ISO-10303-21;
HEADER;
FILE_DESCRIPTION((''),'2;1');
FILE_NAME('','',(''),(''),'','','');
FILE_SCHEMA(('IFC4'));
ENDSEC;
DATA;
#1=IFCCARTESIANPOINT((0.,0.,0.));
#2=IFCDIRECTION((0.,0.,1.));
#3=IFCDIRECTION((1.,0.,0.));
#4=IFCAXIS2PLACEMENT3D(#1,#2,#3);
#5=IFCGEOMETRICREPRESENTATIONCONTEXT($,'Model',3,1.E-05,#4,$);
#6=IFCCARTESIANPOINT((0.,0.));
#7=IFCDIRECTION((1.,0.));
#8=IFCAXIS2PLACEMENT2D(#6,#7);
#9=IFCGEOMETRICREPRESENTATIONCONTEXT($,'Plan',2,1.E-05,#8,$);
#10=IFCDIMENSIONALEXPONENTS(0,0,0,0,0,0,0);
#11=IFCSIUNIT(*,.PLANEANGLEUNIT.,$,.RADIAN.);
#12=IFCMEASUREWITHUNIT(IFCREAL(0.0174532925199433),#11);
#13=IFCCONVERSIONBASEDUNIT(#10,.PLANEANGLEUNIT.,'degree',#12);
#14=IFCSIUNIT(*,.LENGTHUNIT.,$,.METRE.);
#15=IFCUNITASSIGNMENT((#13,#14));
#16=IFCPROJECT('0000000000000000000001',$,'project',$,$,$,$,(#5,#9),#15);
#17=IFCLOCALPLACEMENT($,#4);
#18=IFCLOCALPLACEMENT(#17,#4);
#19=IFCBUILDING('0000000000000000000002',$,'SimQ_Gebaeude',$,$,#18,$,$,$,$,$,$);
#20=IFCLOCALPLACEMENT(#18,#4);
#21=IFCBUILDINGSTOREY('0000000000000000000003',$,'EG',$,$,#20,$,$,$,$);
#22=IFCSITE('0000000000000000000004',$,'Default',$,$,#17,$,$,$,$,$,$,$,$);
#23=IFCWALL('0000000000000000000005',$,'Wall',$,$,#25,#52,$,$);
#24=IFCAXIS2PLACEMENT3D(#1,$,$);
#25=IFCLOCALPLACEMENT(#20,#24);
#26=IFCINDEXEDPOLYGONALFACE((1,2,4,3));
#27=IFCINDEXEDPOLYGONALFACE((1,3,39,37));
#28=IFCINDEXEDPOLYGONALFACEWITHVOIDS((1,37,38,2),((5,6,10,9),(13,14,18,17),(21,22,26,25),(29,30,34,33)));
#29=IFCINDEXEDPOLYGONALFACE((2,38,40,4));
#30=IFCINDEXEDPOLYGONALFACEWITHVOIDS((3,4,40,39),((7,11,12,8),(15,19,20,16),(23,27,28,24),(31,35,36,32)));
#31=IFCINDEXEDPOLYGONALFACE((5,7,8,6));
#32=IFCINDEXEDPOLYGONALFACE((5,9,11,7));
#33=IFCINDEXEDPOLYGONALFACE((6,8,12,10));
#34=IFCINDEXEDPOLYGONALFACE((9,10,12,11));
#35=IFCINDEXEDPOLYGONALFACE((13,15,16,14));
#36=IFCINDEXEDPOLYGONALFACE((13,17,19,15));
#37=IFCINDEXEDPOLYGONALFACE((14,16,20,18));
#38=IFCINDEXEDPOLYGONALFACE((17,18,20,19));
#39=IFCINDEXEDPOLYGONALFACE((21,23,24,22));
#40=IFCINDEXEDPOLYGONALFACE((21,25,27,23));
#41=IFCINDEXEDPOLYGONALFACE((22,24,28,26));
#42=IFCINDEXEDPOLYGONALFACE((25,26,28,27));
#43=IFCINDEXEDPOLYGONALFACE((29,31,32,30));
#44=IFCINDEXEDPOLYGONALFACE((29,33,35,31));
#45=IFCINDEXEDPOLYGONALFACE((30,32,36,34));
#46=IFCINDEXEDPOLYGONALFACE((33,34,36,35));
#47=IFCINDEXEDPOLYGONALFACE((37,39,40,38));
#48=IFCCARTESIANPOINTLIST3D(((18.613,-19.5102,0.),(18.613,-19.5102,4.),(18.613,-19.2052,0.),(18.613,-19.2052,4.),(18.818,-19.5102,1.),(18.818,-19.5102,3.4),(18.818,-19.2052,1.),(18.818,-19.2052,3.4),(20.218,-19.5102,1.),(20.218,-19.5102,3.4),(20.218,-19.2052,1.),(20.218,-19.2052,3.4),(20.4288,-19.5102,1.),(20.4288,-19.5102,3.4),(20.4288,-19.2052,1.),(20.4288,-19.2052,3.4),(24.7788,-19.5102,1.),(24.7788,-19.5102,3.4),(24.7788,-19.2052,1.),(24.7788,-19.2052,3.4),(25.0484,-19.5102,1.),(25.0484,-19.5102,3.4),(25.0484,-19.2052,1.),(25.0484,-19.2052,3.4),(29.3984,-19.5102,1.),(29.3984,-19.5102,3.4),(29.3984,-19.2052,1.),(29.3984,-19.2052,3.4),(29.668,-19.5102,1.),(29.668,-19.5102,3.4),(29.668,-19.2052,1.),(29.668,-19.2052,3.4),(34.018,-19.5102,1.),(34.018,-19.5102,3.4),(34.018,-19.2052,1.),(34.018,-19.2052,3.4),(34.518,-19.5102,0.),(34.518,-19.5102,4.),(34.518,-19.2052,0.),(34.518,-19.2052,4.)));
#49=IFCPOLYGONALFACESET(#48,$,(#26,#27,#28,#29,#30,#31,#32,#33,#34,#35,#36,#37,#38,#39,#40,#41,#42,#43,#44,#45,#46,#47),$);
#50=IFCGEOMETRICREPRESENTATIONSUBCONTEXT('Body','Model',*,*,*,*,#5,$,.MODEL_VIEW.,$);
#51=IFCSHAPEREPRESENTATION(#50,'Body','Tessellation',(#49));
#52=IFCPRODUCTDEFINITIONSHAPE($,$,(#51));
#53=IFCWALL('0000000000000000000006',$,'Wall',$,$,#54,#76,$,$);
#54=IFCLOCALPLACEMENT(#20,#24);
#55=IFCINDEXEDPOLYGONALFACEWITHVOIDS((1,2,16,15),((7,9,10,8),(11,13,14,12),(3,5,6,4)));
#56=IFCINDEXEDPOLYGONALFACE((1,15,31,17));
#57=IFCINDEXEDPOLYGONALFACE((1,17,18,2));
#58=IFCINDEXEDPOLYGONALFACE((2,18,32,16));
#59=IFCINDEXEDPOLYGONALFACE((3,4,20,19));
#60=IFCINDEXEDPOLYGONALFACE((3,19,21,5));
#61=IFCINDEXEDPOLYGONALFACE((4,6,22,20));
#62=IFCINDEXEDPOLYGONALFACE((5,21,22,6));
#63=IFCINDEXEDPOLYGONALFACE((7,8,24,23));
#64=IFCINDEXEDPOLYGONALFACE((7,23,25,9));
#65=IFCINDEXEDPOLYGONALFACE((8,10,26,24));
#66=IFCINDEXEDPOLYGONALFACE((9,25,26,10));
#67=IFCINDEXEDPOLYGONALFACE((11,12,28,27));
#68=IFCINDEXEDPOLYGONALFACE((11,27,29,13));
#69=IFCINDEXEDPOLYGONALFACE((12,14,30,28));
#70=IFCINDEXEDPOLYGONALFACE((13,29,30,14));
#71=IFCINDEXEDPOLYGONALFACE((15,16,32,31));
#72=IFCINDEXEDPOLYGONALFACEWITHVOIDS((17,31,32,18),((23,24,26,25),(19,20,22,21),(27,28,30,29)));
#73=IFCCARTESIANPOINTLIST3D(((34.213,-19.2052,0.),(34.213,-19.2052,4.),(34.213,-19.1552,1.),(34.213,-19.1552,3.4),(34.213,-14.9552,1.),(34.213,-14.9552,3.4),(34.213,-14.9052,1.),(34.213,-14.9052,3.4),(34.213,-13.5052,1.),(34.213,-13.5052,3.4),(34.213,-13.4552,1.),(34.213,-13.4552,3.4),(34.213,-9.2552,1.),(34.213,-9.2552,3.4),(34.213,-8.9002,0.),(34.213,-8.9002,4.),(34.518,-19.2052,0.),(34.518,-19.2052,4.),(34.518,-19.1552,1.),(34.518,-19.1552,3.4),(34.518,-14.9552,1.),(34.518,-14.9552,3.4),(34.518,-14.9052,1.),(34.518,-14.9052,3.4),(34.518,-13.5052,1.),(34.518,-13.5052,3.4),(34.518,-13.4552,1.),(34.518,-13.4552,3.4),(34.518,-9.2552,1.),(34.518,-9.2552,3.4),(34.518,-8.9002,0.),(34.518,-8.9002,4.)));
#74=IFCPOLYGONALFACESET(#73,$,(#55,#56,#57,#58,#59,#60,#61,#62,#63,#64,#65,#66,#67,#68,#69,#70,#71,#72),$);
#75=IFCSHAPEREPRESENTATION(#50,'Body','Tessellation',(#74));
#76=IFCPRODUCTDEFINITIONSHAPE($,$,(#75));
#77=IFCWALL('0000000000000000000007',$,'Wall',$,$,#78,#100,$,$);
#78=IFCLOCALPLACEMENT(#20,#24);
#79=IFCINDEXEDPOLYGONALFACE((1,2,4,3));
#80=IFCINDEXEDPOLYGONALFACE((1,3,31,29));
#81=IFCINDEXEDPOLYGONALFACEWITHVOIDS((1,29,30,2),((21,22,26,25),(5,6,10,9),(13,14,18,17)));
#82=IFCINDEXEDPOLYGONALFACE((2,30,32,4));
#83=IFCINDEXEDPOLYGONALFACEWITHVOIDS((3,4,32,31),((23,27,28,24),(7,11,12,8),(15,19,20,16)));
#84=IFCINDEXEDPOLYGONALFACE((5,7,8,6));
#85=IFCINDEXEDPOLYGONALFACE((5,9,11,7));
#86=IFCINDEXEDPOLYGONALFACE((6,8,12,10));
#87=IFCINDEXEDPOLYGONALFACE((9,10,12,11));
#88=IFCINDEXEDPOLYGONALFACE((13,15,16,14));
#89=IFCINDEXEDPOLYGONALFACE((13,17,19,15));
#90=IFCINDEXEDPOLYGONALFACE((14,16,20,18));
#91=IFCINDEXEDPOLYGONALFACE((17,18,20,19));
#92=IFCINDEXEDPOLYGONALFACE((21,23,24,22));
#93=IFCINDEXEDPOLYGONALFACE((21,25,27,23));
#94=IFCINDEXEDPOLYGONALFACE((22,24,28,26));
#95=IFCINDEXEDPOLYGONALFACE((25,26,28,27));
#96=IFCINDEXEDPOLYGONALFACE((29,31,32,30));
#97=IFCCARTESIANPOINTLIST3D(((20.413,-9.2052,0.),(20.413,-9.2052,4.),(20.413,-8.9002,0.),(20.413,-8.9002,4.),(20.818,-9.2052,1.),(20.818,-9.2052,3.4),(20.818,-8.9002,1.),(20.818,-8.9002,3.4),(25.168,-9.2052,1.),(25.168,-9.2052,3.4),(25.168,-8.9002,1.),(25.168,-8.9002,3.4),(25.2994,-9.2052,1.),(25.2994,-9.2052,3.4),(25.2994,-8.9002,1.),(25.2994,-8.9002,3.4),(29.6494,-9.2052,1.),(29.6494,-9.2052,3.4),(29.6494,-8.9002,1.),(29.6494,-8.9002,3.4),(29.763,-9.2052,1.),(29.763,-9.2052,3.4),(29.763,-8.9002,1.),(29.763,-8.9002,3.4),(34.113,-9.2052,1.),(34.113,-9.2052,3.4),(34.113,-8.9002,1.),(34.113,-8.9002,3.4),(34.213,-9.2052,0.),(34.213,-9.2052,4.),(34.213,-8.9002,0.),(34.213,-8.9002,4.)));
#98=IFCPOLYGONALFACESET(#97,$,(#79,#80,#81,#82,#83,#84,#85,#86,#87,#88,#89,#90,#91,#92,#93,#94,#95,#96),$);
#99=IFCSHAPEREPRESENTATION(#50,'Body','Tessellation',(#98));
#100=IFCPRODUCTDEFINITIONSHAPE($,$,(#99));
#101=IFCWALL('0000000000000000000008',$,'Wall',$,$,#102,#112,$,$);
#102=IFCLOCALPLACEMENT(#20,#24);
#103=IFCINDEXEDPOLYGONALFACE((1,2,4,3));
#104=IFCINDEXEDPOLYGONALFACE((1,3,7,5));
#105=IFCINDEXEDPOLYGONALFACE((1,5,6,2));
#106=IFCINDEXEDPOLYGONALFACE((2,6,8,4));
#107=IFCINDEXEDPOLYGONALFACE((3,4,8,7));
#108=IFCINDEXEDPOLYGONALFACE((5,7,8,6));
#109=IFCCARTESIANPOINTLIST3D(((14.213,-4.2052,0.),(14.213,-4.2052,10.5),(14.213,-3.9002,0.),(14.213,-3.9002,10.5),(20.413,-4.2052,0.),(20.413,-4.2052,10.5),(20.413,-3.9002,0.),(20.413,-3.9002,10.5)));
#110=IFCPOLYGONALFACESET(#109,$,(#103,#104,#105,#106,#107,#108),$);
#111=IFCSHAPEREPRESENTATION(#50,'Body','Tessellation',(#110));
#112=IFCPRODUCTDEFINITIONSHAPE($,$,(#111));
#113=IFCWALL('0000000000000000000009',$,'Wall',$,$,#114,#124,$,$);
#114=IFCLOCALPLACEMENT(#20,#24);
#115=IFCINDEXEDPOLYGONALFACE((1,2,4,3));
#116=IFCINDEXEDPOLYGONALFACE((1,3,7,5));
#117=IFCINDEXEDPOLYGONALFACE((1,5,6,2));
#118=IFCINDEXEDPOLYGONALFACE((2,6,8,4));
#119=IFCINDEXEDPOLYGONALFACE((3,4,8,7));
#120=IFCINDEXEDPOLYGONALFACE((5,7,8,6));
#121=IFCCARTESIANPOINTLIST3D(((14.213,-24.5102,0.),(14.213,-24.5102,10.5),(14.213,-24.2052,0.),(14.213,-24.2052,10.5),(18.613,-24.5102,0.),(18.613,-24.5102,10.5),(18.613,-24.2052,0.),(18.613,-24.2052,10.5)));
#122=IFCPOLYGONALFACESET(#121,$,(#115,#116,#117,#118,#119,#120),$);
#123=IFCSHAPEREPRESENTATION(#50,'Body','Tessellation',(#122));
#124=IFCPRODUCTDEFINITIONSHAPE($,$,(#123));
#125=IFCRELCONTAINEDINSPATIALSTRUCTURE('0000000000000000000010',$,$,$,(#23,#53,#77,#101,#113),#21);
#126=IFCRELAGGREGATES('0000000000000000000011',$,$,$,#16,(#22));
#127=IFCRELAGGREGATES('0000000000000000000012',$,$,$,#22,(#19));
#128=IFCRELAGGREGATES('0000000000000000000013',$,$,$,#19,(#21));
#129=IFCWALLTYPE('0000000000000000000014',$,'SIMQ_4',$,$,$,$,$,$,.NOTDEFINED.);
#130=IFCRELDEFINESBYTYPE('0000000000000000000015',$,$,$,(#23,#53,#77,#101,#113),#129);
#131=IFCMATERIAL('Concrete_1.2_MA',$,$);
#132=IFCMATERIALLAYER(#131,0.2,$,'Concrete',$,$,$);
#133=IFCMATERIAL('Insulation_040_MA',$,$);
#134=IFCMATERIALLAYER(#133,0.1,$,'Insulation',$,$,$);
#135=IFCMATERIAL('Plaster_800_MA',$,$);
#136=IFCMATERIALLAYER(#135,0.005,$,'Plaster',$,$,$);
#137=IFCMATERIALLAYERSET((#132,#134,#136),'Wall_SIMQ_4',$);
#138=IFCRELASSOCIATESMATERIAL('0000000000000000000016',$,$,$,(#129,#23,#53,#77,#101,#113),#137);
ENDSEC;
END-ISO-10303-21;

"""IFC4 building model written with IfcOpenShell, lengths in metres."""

from ifc_helpers import new_model, entity, si_unit, converted_unit, frame, origin_with_axes, origin_2d_with_axis, place, context, subcontext, project, spatial, line, indexed_curve, outline, extrude, source, transform, mapped, material, layer, layer_set, layer_usage, type_object, element, save


model = new_model("IFC4")

# Units and contexts
model_context = context("Model", 3, precision=1e-05, world=origin_with_axes())
plan_context = context("Plan", 2, precision=1e-05, world=origin_2d_with_axis())
body_context_1 = subcontext(model_context, "Body", "Model", "MODEL_VIEW")
ifc_project = project(units=[converted_unit("PLANEANGLEUNIT", "degree", entity("IfcReal", 0.0174532925199433), si_unit("PLANEANGLEUNIT", "RADIAN"), dimensions=[0, 0, 0, 0, 0, 0, 0]), si_unit("LENGTHUNIT", "METRE")], contexts=[model_context, plan_context])

# Site, building, storey
site_placement = place(None, origin_with_axes())
site = spatial("IfcSite", under=ifc_project, at=site_placement, Name="Default")
building_placement = place(site_placement, origin_with_axes())
building = spatial("IfcBuilding", under=site, at=building_placement, Name="SimQ_Gebaeude")
storey_placement = place(building_placement, origin_with_axes())
storey = spatial("IfcBuildingStorey", under=building, at=storey_placement, Name="EG")

# Shared definitions
ifc_material_1 = material(Name="Insulation_040_MA")
ifc_material_2 = material(Name="Concrete_1.2_MA")

# Shared definitions
ifc_layer_1 = layer(ifc_material_2, 0.2, Name="Concrete")
ifc_layer_2 = layer(ifc_material_1, 0.1, Name="Insulation")
ifc_material_3 = material(Name="Plaster_800_MA")
ifc_layer_3 = layer(ifc_material_3, 0.005, Name="Plaster")
ifc_layer_set_1 = layer_set([ifc_layer_1, ifc_layer_2, ifc_layer_3], Name="Wall_SIMQ_4")
wall_type_1 = type_object("IfcWallType", Name="SIMQ_4", PredefinedType="NOTDEFINED", material=ifc_layer_set_1)
shared_shape_1 = source(origin_with_axes(), body_context_1, "Body", "SweptSolid", [
    extrude(outline(indexed_curve([(0.0, 0.0), (4.35, 0.0), (4.35, 2.4), (0.0, 2.4)], segments=[line(1, 2, 3, 4, 1)])), frame((0.0, -0.6, 0.0), z_axis=(0.0, -1.0, 0.0), x_axis=(1.0, 0.0, 0.0)), (0.0, 0.0, -1.0), 1.2),
])

# Walls, openings
ifc_layer_usage_1 = layer_usage(ifc_layer_set_1, "AXIS2", "POSITIVE", 0.0)
wall_1_placement = place(storey_placement, frame((18.613, -19.5102, 0.0), z_axis=(0.0, 0.0, 1.0), x_axis=(1.0, 0.0, 0.0)))
wall_1 = element("IfcWall", 1, at=wall_1_placement, inside=storey, type_object=wall_type_1, material=ifc_layer_usage_1, Name="Wall", context=body_context_1, shape_type="SweptSolid", body=[
    extrude(outline(indexed_curve([(0.0, 0.0), (0.0, 0.305), (15.905, 0.305), (15.905, 0.0), (0.0, 0.0)], self_intersect=False)), origin_with_axes(), (0.0, 0.0, 1.0), 4.0),
])
opening_1_placement = place(wall_1_placement, frame((1.8157, 0.0, 1.0), z_axis=(0.0, 0.0, 1.0), x_axis=(1.0, 0.0, 0.0)))
element("IfcOpeningElement", 2, at=opening_1_placement, cuts=wall_1, PredefinedType="OPENING", context=body_context_1, shape_type="MappedRepresentation", body=[
    mapped(shared_shape_1, transform((0.0, 0.0, 0.0), x_axis=(1.0, 0.0, 0.0), y_axis=(0.0, 1.0, 0.0), z_axis=(0.0, 0.0, 1.0), scale=1.0)),
])
opening_2_placement = place(wall_1_placement, frame((6.4354, 0.0, 1.0), z_axis=(0.0, 0.0, 1.0), x_axis=(1.0, 0.0, 0.0)))
element("IfcOpeningElement", 3, at=opening_2_placement, cuts=wall_1, PredefinedType="OPENING", context=body_context_1, shape_type="MappedRepresentation", body=[
    mapped(shared_shape_1, transform((0.0, 0.0, 0.0), x_axis=(1.0, 0.0, 0.0), y_axis=(0.0, 1.0, 0.0), z_axis=(0.0, 0.0, 1.0), scale=1.0)),
])
opening_3_placement = place(wall_1_placement, frame((11.055, 0.0, 1.0), z_axis=(0.0, 0.0, 1.0), x_axis=(1.0, 0.0, 0.0)))
element("IfcOpeningElement", 4, at=opening_3_placement, cuts=wall_1, PredefinedType="OPENING", context=body_context_1, shape_type="MappedRepresentation", body=[
    mapped(shared_shape_1, transform((0.0, 0.0, 0.0), x_axis=(1.0, 0.0, 0.0), y_axis=(0.0, 1.0, 0.0), z_axis=(0.0, 0.0, 1.0), scale=1.0)),
])
shared_shape_2 = source(origin_with_axes(), body_context_1, "Body", "SweptSolid", [
    extrude(outline(indexed_curve([(0.0, 0.0), (1.4, 0.0), (1.4, 2.4), (0.0, 2.4)], segments=[line(1, 2, 3, 4, 1)])), frame((0.0, -0.6, 0.0), z_axis=(0.0, -1.0, 0.0), x_axis=(1.0, 0.0, 0.0)), (0.0, 0.0, -1.0), 1.2),
])
opening_4_placement = place(wall_1_placement, frame((0.205, 0.0, 1.0), z_axis=(0.0, 0.0, 1.0), x_axis=(1.0, 0.0, 0.0)))
element("IfcOpeningElement", 5, at=opening_4_placement, cuts=wall_1, PredefinedType="OPENING", context=body_context_1, shape_type="MappedRepresentation", body=[
    mapped(shared_shape_2, transform((0.0, 0.0, 0.0), x_axis=(1.0, 0.0, 0.0), y_axis=(0.0, 1.0, 0.0), z_axis=(0.0, 0.0, 1.0), scale=1.0)),
])
ifc_layer_usage_2 = layer_usage(ifc_layer_set_1, "AXIS2", "POSITIVE", 0.0)
wall_2_placement = place(storey_placement, frame((34.518, -19.2052, 0.0), z_axis=(0.0, 0.0, 1.0), x_axis=(0.0, 1.0, 0.0)))
wall_2 = element("IfcWall", 6, at=wall_2_placement, inside=storey, type_object=wall_type_1, material=ifc_layer_usage_2, Name="Wall", context=body_context_1, shape_type="SweptSolid", body=[
    extrude(outline(indexed_curve([(0.0, 0.0), (0.0, 0.305), (10.305, 0.305), (10.305, 0.0), (0.0, 0.0)], self_intersect=False)), origin_with_axes(), (0.0, 0.0, 1.0), 4.0),
])
shared_shape_3 = source(origin_with_axes(), body_context_1, "Body", "SweptSolid", [
    extrude(outline(indexed_curve([(0.0, 0.0), (4.2, 0.0), (4.2, 2.4), (0.0, 2.4)], segments=[line(1, 2, 3, 4, 1)])), frame((0.0, -0.1, 0.0), z_axis=(0.0, -1.0, 0.0), x_axis=(1.0, 0.0, 0.0)), (0.0, 0.0, -1.0), 0.505),
])
opening_5_placement = place(wall_2_placement, frame((0.05, 0.0, 1.0), z_axis=(0.0, 0.0, 1.0), x_axis=(1.0, 0.0, 0.0)))
element("IfcOpeningElement", 7, at=opening_5_placement, cuts=wall_2, PredefinedType="OPENING", context=body_context_1, shape_type="MappedRepresentation", body=[
    mapped(shared_shape_3, transform((0.0, 0.0, 0.0), x_axis=(1.0, 0.0, 0.0), y_axis=(0.0, 1.0, 0.0), z_axis=(0.0, 0.0, 1.0), scale=1.0)),
])
opening_6_placement = place(wall_2_placement, frame((5.75, 0.0, 1.0), z_axis=(0.0, 0.0, 1.0), x_axis=(1.0, 0.0, 0.0)))
element("IfcOpeningElement", 8, at=opening_6_placement, cuts=wall_2, PredefinedType="OPENING", context=body_context_1, shape_type="MappedRepresentation", body=[
    mapped(shared_shape_3, transform((0.0, 0.0, 0.0), x_axis=(1.0, 0.0, 0.0), y_axis=(0.0, 1.0, 0.0), z_axis=(0.0, 0.0, 1.0), scale=1.0)),
])
opening_7_placement = place(wall_2_placement, frame((4.3, 0.0, 1.0), z_axis=(0.0, 0.0, 1.0), x_axis=(1.0, 0.0, 0.0)))
element("IfcOpeningElement", 9, at=opening_7_placement, cuts=wall_2, PredefinedType="OPENING", context=body_context_1, shape_type="MappedRepresentation", body=[
    mapped(shared_shape_2, transform((0.0, 0.0, 0.0), x_axis=(1.0, 0.0, 0.0), y_axis=(0.0, 1.0, 0.0), z_axis=(0.0, 0.0, 1.0), scale=1.0)),
])
ifc_layer_usage_3 = layer_usage(ifc_layer_set_1, "AXIS2", "POSITIVE", 0.0)
wall_3_placement = place(storey_placement, frame((34.213, -8.9002, 0.0), z_axis=(0.0, 0.0, 1.0), x_axis=(-1.0, 0.0, 0.0)))
wall_3 = element("IfcWall", 10, at=wall_3_placement, inside=storey, type_object=wall_type_1, material=ifc_layer_usage_3, Name="Wall", context=body_context_1, shape_type="SweptSolid", body=[
    extrude(outline(indexed_curve([(0.0, 0.0), (0.0, 0.305), (13.8, 0.305), (13.8, 0.0), (0.0, 0.0)], self_intersect=False)), origin_with_axes(), (0.0, 0.0, 1.0), 4.0),
])
opening_8_placement = place(wall_3_placement, frame((0.1, 0.0, 1.0), z_axis=(0.0, 0.0, 1.0), x_axis=(1.0, 0.0, 0.0)))
element("IfcOpeningElement", 11, at=opening_8_placement, cuts=wall_3, PredefinedType="OPENING", context=body_context_1, shape_type="MappedRepresentation", body=[
    mapped(shared_shape_1, transform((0.0, 0.0, 0.0), x_axis=(1.0, 0.0, 0.0), y_axis=(0.0, 1.0, 0.0), z_axis=(0.0, 0.0, 1.0), scale=1.0)),
])
opening_9_placement = place(wall_3_placement, frame((4.5636, 0.0, 1.0), z_axis=(0.0, 0.0, 1.0), x_axis=(1.0, 0.0, 0.0)))
element("IfcOpeningElement", 12, at=opening_9_placement, cuts=wall_3, PredefinedType="OPENING", context=body_context_1, shape_type="MappedRepresentation", body=[
    mapped(shared_shape_1, transform((0.0, 0.0, 0.0), x_axis=(1.0, 0.0, 0.0), y_axis=(0.0, 1.0, 0.0), z_axis=(0.0, 0.0, 1.0), scale=1.0)),
])
opening_10_placement = place(wall_3_placement, frame((9.045, 0.0, 1.0), z_axis=(0.0, 0.0, 1.0), x_axis=(1.0, 0.0, 0.0)))
element("IfcOpeningElement", 13, at=opening_10_placement, cuts=wall_3, PredefinedType="OPENING", context=body_context_1, shape_type="MappedRepresentation", body=[
    mapped(shared_shape_1, transform((0.0, 0.0, 0.0), x_axis=(1.0, 0.0, 0.0), y_axis=(0.0, 1.0, 0.0), z_axis=(0.0, 0.0, 1.0), scale=1.0)),
])

# Walls
ifc_layer_usage_4 = layer_usage(ifc_layer_set_1, "AXIS2", "POSITIVE", 0.0)
wall_4_placement = place(storey_placement, frame((20.413, -3.9002, 0.0), z_axis=(0.0, 0.0, 1.0), x_axis=(-1.0, 0.0, 0.0)))
element("IfcWall", 14, at=wall_4_placement, inside=storey, type_object=wall_type_1, material=ifc_layer_usage_4, Name="Wall", context=body_context_1, shape_type="SweptSolid", body=[
    extrude(outline(indexed_curve([(0.0, 0.0), (0.0, 0.305), (6.2, 0.305), (6.2, 0.0), (0.0, 0.0)], self_intersect=False)), origin_with_axes(), (0.0, 0.0, 1.0), 10.5),
])
ifc_layer_usage_5 = layer_usage(ifc_layer_set_1, "AXIS2", "POSITIVE", 0.0)
wall_5_placement = place(storey_placement, frame((14.213, -24.5102, 0.0), z_axis=(0.0, 0.0, 1.0), x_axis=(1.0, 0.0, 0.0)))
element("IfcWall", 15, at=wall_5_placement, inside=storey, type_object=wall_type_1, material=ifc_layer_usage_5, Name="Wall", context=body_context_1, shape_type="SweptSolid", body=[
    extrude(outline(indexed_curve([(0.0, 0.0), (0.0, 0.305), (4.4, 0.305), (4.4, 0.0), (0.0, 0.0)], self_intersect=False)), origin_with_axes(), (0.0, 0.0, 1.0), 10.5),
])

save(model, "model.ifc")
